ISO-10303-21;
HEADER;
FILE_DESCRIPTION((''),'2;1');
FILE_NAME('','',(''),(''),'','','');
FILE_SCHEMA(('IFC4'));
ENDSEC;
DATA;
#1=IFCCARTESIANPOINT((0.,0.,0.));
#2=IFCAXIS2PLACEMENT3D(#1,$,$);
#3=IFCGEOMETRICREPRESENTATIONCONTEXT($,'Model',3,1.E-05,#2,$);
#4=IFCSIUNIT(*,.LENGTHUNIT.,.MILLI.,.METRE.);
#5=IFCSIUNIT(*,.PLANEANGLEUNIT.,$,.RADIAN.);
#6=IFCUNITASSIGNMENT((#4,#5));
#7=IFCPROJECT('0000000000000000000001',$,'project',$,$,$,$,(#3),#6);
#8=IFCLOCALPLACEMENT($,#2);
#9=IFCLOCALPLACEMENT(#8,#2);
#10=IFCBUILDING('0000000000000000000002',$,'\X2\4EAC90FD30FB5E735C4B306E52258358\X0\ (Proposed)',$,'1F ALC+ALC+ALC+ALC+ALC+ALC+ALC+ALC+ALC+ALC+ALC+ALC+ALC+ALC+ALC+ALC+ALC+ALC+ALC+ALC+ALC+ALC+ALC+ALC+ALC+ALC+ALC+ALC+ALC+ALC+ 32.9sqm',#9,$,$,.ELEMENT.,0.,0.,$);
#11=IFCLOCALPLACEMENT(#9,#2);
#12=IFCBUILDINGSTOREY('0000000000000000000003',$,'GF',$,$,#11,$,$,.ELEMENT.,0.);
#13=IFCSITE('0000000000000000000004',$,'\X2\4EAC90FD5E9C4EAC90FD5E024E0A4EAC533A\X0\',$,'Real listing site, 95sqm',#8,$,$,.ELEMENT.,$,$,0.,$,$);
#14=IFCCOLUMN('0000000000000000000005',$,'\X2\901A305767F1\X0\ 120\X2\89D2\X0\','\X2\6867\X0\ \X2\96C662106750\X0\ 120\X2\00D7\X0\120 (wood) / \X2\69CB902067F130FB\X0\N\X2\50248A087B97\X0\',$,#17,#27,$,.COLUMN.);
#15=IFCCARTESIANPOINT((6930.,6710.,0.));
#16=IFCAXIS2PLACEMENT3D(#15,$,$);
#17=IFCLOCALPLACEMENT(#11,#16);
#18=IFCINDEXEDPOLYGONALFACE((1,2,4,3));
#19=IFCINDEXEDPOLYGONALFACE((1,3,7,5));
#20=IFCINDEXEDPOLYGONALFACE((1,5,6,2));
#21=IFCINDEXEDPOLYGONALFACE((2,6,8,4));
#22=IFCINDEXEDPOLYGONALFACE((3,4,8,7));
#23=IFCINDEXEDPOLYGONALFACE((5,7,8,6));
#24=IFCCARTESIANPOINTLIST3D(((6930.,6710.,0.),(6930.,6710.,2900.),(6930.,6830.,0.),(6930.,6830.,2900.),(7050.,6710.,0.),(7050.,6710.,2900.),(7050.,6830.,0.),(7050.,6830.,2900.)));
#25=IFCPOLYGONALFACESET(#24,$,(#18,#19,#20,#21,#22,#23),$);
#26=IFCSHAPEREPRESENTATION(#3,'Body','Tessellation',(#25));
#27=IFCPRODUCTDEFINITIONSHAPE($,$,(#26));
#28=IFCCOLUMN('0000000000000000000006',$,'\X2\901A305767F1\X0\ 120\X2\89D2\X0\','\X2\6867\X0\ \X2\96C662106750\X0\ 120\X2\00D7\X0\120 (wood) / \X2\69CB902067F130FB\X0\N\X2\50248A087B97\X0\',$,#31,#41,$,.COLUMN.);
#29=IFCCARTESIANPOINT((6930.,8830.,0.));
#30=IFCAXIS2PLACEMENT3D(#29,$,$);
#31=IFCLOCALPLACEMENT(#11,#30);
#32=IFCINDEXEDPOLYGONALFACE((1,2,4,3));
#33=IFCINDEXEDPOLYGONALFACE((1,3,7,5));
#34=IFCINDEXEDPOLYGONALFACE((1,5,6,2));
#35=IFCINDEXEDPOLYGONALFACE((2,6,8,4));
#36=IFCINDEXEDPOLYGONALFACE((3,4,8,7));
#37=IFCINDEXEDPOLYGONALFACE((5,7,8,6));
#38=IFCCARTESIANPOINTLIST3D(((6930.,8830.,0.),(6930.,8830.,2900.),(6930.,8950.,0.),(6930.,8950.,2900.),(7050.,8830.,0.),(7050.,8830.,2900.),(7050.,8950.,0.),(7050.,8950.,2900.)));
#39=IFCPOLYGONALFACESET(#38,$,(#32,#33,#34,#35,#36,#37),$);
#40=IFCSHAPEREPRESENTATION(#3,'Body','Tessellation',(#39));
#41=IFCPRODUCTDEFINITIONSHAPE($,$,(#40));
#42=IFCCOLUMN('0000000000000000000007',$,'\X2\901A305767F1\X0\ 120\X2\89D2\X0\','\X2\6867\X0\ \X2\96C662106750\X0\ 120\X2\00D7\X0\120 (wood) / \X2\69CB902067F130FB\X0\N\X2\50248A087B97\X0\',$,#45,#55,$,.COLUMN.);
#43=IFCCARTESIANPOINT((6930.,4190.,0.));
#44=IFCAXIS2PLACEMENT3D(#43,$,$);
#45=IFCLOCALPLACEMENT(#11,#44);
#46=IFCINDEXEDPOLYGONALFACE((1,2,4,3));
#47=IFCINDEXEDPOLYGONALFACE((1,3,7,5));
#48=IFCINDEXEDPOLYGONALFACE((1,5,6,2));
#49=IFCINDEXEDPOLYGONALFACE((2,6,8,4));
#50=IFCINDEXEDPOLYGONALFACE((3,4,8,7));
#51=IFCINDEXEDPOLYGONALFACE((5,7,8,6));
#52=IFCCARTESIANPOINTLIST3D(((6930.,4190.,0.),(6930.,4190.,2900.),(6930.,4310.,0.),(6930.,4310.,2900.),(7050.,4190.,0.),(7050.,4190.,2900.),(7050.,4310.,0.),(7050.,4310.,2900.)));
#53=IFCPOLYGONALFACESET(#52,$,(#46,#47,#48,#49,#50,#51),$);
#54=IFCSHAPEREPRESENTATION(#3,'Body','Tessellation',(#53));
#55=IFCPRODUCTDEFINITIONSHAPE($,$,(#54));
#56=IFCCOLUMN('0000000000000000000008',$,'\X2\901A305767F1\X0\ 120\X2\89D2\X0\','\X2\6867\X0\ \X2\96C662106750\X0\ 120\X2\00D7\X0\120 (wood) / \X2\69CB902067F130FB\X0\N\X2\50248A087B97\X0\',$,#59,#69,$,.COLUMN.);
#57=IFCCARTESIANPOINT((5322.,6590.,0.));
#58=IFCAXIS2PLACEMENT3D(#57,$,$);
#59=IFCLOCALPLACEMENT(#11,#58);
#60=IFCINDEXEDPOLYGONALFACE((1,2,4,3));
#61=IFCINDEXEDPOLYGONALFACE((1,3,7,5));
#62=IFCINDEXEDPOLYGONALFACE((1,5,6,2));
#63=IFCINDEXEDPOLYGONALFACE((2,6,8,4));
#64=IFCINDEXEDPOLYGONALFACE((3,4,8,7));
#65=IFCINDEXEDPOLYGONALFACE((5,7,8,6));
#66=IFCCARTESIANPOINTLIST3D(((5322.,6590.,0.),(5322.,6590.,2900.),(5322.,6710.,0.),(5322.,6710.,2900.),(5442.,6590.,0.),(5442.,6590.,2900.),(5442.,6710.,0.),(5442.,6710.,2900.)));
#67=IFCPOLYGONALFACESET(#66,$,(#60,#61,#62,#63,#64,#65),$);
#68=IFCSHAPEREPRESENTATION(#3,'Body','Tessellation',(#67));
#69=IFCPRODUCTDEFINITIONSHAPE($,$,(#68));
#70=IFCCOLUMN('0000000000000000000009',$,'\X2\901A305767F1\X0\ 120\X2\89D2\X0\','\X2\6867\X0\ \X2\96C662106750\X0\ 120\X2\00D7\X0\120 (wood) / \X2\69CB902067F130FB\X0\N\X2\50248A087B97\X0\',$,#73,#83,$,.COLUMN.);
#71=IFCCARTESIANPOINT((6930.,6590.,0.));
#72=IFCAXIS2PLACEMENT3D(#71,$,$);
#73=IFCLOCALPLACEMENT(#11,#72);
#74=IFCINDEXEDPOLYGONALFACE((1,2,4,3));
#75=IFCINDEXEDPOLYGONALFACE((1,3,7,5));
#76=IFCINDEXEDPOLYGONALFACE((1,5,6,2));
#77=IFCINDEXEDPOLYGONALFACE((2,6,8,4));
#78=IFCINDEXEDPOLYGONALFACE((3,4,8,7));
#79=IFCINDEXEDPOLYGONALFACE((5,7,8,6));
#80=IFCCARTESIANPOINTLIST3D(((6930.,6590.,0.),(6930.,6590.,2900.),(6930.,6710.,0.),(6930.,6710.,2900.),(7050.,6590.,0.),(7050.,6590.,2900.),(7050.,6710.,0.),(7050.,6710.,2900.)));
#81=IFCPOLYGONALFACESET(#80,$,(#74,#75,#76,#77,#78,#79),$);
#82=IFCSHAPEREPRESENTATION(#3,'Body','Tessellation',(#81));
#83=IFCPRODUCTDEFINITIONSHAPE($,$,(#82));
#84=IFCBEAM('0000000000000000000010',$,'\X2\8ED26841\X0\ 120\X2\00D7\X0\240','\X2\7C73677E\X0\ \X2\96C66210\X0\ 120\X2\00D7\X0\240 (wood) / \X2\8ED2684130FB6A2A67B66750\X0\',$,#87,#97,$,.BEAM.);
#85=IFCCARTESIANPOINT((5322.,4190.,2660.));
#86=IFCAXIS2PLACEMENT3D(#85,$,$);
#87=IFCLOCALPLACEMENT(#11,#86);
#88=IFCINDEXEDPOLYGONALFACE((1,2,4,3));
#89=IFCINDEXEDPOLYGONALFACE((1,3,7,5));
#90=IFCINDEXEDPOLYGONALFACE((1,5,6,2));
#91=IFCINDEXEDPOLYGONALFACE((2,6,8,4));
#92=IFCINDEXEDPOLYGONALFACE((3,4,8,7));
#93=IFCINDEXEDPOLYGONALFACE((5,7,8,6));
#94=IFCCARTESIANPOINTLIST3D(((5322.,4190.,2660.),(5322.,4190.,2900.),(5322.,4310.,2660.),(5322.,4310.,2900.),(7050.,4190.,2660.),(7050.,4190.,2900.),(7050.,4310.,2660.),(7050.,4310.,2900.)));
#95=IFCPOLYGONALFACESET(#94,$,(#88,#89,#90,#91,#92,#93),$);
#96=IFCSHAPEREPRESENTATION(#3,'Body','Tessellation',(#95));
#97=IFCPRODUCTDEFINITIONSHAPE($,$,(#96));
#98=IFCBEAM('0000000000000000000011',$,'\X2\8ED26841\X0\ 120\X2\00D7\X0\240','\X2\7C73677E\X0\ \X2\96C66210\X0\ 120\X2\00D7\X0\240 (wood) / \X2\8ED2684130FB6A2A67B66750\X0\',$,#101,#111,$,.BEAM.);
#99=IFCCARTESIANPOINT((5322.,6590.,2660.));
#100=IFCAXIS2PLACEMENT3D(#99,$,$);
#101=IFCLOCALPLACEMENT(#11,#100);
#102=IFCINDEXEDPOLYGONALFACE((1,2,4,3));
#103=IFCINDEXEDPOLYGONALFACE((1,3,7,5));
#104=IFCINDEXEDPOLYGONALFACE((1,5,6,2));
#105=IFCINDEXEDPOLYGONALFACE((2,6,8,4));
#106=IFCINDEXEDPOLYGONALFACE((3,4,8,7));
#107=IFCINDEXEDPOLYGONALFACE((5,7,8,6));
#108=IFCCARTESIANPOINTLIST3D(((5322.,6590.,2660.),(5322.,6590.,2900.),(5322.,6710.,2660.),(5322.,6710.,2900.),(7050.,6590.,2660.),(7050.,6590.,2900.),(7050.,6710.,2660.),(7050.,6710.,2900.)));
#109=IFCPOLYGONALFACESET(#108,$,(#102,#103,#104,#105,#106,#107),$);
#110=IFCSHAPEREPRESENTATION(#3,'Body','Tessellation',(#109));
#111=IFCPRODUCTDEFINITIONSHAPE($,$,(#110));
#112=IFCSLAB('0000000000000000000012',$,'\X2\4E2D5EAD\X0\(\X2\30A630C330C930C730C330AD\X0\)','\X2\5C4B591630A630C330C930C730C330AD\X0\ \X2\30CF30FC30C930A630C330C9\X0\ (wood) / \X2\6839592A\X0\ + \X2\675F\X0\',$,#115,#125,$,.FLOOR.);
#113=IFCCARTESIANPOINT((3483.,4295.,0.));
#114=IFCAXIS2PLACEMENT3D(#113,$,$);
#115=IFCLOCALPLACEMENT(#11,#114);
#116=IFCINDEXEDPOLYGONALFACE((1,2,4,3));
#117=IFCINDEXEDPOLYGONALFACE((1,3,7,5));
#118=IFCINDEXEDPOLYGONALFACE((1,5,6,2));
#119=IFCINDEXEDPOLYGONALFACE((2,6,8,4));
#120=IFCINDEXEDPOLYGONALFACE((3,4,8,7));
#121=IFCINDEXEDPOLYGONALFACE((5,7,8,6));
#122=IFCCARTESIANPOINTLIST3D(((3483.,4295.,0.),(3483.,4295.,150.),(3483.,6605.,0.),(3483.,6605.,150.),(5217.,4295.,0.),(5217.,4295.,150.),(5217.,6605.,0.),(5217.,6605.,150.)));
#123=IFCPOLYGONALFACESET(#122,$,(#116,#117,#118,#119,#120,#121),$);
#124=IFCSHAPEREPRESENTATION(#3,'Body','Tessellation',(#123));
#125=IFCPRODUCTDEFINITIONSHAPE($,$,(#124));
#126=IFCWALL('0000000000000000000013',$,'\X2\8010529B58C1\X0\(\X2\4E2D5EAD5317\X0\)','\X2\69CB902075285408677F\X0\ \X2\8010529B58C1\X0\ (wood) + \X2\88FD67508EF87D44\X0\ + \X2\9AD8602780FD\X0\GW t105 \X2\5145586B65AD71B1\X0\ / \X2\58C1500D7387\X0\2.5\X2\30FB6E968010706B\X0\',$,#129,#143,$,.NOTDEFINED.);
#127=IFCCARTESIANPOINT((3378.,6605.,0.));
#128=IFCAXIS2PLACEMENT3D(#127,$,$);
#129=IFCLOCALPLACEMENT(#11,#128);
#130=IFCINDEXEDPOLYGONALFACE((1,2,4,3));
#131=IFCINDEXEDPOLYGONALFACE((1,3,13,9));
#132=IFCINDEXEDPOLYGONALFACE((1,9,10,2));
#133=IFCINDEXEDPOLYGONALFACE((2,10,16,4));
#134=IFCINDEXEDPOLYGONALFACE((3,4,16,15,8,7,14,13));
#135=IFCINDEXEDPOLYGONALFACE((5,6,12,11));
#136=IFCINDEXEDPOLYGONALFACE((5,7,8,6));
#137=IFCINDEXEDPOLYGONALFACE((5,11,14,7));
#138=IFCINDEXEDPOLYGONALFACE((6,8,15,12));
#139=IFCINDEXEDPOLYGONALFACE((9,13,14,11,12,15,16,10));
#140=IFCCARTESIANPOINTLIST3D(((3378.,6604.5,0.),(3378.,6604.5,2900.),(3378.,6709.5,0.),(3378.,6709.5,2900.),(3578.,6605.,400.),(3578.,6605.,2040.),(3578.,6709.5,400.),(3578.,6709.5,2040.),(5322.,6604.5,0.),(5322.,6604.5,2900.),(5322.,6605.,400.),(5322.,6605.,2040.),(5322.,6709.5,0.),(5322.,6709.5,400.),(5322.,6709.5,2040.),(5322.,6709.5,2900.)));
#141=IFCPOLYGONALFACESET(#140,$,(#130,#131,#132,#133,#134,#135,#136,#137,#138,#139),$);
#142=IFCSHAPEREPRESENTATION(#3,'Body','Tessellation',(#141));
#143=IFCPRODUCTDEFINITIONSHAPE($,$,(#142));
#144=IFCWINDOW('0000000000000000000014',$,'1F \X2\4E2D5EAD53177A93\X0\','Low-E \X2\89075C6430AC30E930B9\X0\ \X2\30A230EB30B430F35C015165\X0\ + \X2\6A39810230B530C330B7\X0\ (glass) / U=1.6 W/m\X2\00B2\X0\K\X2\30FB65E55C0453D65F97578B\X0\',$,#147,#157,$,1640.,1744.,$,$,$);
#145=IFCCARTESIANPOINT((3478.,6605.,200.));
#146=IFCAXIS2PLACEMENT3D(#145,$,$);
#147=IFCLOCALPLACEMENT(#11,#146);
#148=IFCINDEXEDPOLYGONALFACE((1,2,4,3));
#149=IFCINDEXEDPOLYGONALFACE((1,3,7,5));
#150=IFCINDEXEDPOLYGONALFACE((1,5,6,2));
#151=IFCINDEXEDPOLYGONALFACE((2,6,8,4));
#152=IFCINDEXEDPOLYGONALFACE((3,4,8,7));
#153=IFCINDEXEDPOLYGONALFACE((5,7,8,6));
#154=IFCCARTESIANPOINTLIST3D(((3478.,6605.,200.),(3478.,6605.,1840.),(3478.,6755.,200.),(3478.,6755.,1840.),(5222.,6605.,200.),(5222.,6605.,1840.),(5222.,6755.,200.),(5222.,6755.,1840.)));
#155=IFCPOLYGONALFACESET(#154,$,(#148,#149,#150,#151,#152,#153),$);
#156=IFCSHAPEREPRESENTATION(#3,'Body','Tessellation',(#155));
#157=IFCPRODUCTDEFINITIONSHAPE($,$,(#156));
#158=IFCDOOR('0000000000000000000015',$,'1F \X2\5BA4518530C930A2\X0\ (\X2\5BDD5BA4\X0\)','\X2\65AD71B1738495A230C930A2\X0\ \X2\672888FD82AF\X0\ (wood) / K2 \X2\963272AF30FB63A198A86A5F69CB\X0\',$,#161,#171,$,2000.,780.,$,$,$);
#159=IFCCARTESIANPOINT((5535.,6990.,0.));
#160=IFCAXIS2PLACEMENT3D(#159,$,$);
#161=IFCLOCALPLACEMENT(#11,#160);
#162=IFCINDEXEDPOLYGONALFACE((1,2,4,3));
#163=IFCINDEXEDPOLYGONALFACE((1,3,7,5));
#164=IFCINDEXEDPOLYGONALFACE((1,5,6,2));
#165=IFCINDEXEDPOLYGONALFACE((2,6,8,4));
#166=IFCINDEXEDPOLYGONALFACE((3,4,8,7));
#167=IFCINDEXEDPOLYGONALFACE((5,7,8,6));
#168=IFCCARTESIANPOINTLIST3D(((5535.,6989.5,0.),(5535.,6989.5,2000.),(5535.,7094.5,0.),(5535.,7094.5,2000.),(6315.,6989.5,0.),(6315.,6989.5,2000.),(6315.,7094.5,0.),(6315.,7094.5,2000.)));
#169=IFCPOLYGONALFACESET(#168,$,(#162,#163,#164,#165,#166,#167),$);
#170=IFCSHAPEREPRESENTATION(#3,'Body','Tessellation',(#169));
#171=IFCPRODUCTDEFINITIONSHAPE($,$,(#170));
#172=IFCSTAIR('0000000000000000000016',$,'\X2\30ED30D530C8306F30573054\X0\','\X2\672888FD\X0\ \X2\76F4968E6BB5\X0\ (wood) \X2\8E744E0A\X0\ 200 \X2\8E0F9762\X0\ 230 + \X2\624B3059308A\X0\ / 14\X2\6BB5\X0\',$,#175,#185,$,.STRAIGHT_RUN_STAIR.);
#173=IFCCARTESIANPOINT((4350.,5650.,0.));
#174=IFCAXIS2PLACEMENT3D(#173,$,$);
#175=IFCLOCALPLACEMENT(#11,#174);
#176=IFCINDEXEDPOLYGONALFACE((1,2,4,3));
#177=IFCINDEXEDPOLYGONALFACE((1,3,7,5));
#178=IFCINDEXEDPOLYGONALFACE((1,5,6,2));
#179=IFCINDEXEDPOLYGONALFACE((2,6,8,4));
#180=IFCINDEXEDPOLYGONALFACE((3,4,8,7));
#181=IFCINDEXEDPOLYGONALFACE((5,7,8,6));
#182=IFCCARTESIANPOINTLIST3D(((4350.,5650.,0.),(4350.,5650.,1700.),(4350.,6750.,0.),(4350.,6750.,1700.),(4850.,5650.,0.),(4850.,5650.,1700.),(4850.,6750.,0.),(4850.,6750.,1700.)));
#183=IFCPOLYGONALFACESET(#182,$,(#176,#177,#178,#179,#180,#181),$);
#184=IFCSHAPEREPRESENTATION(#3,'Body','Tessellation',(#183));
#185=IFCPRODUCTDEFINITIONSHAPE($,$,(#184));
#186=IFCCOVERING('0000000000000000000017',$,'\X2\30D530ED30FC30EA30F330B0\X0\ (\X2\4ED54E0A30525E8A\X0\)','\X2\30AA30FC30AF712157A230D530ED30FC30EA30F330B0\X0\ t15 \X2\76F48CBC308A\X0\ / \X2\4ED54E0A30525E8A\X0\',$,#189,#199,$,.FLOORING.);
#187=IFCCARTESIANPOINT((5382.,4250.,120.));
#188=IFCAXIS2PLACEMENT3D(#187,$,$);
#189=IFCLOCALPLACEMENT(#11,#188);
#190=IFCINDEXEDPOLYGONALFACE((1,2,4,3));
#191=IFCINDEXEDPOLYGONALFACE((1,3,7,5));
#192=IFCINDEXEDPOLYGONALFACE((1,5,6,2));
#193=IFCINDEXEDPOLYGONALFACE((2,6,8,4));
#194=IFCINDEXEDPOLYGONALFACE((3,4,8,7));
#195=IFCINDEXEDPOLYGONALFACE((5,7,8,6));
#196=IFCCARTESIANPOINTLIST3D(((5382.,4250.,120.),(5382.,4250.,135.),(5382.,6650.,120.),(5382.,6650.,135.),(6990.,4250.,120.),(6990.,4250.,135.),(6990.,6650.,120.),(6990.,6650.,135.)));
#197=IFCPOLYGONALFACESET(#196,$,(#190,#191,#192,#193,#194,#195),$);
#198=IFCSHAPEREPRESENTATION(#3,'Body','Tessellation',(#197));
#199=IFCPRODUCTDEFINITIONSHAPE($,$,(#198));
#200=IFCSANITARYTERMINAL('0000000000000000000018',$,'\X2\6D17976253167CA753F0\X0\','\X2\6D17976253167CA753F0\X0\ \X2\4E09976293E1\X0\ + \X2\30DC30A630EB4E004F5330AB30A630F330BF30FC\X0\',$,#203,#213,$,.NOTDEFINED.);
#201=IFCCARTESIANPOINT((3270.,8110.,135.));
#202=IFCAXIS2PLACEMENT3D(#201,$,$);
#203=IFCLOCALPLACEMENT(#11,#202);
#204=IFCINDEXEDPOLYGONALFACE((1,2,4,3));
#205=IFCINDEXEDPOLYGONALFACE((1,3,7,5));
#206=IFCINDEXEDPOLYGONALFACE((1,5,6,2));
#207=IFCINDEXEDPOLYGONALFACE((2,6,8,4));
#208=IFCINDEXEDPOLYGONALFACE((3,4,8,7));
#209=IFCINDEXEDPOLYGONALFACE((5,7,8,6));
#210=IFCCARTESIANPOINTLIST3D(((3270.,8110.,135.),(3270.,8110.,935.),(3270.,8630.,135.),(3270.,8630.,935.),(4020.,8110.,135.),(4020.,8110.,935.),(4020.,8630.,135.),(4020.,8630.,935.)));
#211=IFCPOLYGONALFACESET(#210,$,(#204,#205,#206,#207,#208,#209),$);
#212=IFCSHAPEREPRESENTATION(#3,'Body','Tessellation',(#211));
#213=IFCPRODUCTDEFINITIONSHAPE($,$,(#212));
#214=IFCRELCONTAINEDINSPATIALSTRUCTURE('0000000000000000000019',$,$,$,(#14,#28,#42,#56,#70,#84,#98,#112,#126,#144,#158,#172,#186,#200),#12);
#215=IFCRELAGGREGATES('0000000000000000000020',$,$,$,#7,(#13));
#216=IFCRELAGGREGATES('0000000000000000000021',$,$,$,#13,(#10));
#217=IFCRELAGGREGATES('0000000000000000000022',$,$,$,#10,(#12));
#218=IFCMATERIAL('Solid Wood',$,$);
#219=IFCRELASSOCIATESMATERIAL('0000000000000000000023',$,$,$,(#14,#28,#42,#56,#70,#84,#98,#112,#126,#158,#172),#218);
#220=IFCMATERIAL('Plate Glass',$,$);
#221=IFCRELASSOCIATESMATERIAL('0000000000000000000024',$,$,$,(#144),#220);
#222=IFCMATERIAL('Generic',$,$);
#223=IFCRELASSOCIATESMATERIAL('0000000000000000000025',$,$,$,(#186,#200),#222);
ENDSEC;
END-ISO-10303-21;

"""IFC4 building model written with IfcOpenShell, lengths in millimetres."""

from ifc_helpers import new_model, si_unit, frame, frame_2d, origin, place, context, project, spatial, rectangle, extrude, material, element, fill, save


model = new_model("IFC4")

# Units and contexts
model_context = context("Model", 3, precision=1e-05, world=origin())
ifc_project = project(units=[si_unit("LENGTHUNIT", "METRE", prefix="MILLI"), si_unit("PLANEANGLEUNIT", "RADIAN")], contexts=[model_context])

# Site, building, storey
site_placement = place(None, origin())
site = spatial("IfcSite", under=ifc_project, at=site_placement, Name="京都府京都市上京区", ObjectType="Real listing site, 95sqm", CompositionType="ELEMENT", RefElevation=0.0)
building_placement = place(site_placement, origin())
building = spatial("IfcBuilding", under=site, at=building_placement, Name="京都・平屋の別荘 (Proposed)", ObjectType="1F ALC+ALC+ALC+ALC+ALC+ALC+ALC+ALC+ALC+ALC+ALC+ALC+ALC+ALC+ALC+ALC+ALC+ALC+ALC+ALC+ALC+ALC+ALC+ALC+ALC+ALC+ALC+ALC+ALC+ALC+ 32.9sqm", CompositionType="ELEMENT", ElevationOfRefHeight=0.0, ElevationOfTerrain=0.0)
storey_placement = place(building_placement, origin())
storey = spatial("IfcBuildingStorey", under=building, at=storey_placement, Name="GF", CompositionType="ELEMENT", Elevation=0.0)

# Columns
ifc_material_1 = material(Name="Solid Wood")
column_1_placement = place(storey_placement, frame((6930.0, 6710.0, 0.0)))
element("IfcColumn", 1, at=column_1_placement, inside=storey, material=ifc_material_1, Name="通し柱 120角", Description="桧 集成材 120×120 (wood) / 構造柱・N値計算", PredefinedType="COLUMN", context=model_context, shape_type="SweptSolid", body=[
    extrude(rectangle(XDim=120.0, YDim=120.0, at=frame_2d((60.0, 60.0))), frame((6930.0, 6710.0, 0.0)), (0.0, 0.0, 1.0), 2900.0),
])
column_2_placement = place(storey_placement, frame((6930.0, 8830.0, 0.0)))
element("IfcColumn", 2, at=column_2_placement, inside=storey, material=ifc_material_1, Name="通し柱 120角", Description="桧 集成材 120×120 (wood) / 構造柱・N値計算", PredefinedType="COLUMN", context=model_context, shape_type="SweptSolid", body=[
    extrude(rectangle(XDim=120.0, YDim=120.0, at=frame_2d((60.0, 60.0))), frame((6930.0, 8830.0, 0.0)), (0.0, 0.0, 1.0), 2900.0),
])
column_3_placement = place(storey_placement, frame((6930.0, 4190.0, 0.0)))
element("IfcColumn", 3, at=column_3_placement, inside=storey, material=ifc_material_1, Name="通し柱 120角", Description="桧 集成材 120×120 (wood) / 構造柱・N値計算", PredefinedType="COLUMN", context=model_context, shape_type="SweptSolid", body=[
    extrude(rectangle(XDim=120.0, YDim=120.0, at=frame_2d((60.0, 60.0))), frame((6930.0, 4190.0, 0.0)), (0.0, 0.0, 1.0), 2900.0),
])
column_4_placement = place(storey_placement, frame((5322.0, 6590.0, 0.0)))
element("IfcColumn", 4, at=column_4_placement, inside=storey, material=ifc_material_1, Name="通し柱 120角", Description="桧 集成材 120×120 (wood) / 構造柱・N値計算", PredefinedType="COLUMN", context=model_context, shape_type="SweptSolid", body=[
    extrude(rectangle(XDim=120.0, YDim=120.0, at=frame_2d((60.0, 60.0))), frame((5322.0, 6590.0, 0.0)), (0.0, 0.0, 1.0), 2900.0),
])
column_5_placement = place(storey_placement, frame((6930.0, 6590.0, 0.0)))
element("IfcColumn", 5, at=column_5_placement, inside=storey, material=ifc_material_1, Name="通し柱 120角", Description="桧 集成材 120×120 (wood) / 構造柱・N値計算", PredefinedType="COLUMN", context=model_context, shape_type="SweptSolid", body=[
    extrude(rectangle(XDim=120.0, YDim=120.0, at=frame_2d((60.0, 60.0))), frame((6930.0, 6590.0, 0.0)), (0.0, 0.0, 1.0), 2900.0),
])

# Beams
beam_1_placement = place(storey_placement, frame((5322.0, 4190.0, 2660.0)))
element("IfcBeam", 6, at=beam_1_placement, inside=storey, material=ifc_material_1, Name="軒桁 120×240", Description="米松 集成 120×240 (wood) / 軒桁・横架材", PredefinedType="BEAM", context=model_context, shape_type="SweptSolid", body=[
    extrude(rectangle(XDim=1728.0, YDim=120.0, at=frame_2d((864.0, 60.0))), frame((5322.0, 4190.0, 2660.0)), (0.0, 0.0, 1.0), 240.0),
])
beam_2_placement = place(storey_placement, frame((5322.0, 6590.0, 2660.0)))
element("IfcBeam", 7, at=beam_2_placement, inside=storey, material=ifc_material_1, Name="軒桁 120×240", Description="米松 集成 120×240 (wood) / 軒桁・横架材", PredefinedType="BEAM", context=model_context, shape_type="SweptSolid", body=[
    extrude(rectangle(XDim=1728.0, YDim=120.0, at=frame_2d((864.0, 60.0))), frame((5322.0, 6590.0, 2660.0)), (0.0, 0.0, 1.0), 240.0),
])

# Slab
slab_placement = place(storey_placement, frame((3483.0, 4295.0, 0.0)))
element("IfcSlab", 8, at=slab_placement, inside=storey, material=ifc_material_1, Name="中庭(ウッドデッキ)", Description="屋外ウッドデッキ ハードウッド (wood) / 根太 + 束", PredefinedType="FLOOR", context=model_context, shape_type="SweptSolid", body=[
    extrude(rectangle(XDim=1734.0, YDim=2310.0, at=frame_2d((867.0, 1155.0))), frame((3483.0, 4295.0, 0.0)), (0.0, 0.0, 1.0), 150.0),
])

# Wall, opening, window
wall_1_placement = place(storey_placement, frame((3378.0, 6605.0, 0.0)))
wall_1 = element("IfcWall", 9, at=wall_1_placement, inside=storey, material=ifc_material_1, Name="耐力壁(中庭北)", Description="構造用合板 耐力壁 (wood) + 製材軸組 + 高性能GW t105 充填断熱 / 壁倍率2.5・準耐火", PredefinedType="NOTDEFINED", context=model_context, shape_type="SweptSolid", body=[
    extrude(rectangle(XDim=1944.0, YDim=105.0, at=frame_2d((972.0, 52.0))), frame((3378.0, 6605.0, 0.0)), (0.0, 0.0, 1.0), 2900.0),
])
opening_placement = place(storey_placement, frame((3478.0, 6605.0, 200.0)))
opening = element("IfcOpeningElement", 10, at=opening_placement, cuts=wall_1, PredefinedType="NOTDEFINED", context=model_context, shape_type="SweptSolid", body=[
    extrude(rectangle(XDim=1744.0, YDim=150.0, at=frame_2d((872.0, 75.0))), frame((3478.0, 6605.0, 200.0)), (0.0, 0.0, 1.0), 1640.0),
])
ifc_material_2 = material(Name="Plate Glass")
window_placement = place(storey_placement, frame((3478.0, 6605.0, 200.0)))
window = element("IfcWindow", 11, at=window_placement, inside=storey, material=ifc_material_2, Name="1F 中庭北窓", Description="Low-E 複層ガラス アルゴン封入 + 樹脂サッシ (glass) / U=1.6 W/m²K・日射取得型", OverallHeight=1640.0, OverallWidth=1744.0, context=model_context, shape_type="SweptSolid", body=[
    extrude(rectangle(XDim=1744.0, YDim=150.0, at=frame_2d((872.0, 75.0))), frame((3478.0, 6605.0, 200.0)), (0.0, 0.0, 1.0), 1640.0),
])
fill(opening, window)

# Door
door_placement = place(storey_placement, frame((5535.0, 6990.0, 0.0)))
element("IfcDoor", 12, at=door_placement, inside=storey, material=ifc_material_1, Name="1F 室内ドア (寝室)", Description="断熱玄関ドア 木製芯 (wood) / K2 防犯・採風機構", OverallHeight=2000.0, OverallWidth=780.0, context=model_context, shape_type="SweptSolid", body=[
    extrude(rectangle(XDim=780.0, YDim=105.0, at=frame_2d((390.0, 52.0))), frame((5535.0, 6990.0, 0.0)), (0.0, 0.0, 1.0), 2000.0),
])

# Stair
stair_placement = place(storey_placement, frame((4350.0, 5650.0, 0.0)))
element("IfcStair", 13, at=stair_placement, inside=storey, material=ifc_material_1, Name="ロフトはしご", Description="木製 直階段 (wood) 蹴上 200 踏面 230 + 手すり / 14段", PredefinedType="STRAIGHT_RUN_STAIR", context=model_context, shape_type="SweptSolid", body=[
    extrude(rectangle(XDim=500.0, YDim=1100.0, at=frame_2d((250.0, 550.0))), frame((4350.0, 5650.0, 0.0)), (0.0, 0.0, 1.0), 1700.0),
])

# Covering
ifc_material_3 = material(Name="Generic")
covering_placement = place(storey_placement, frame((5382.0, 4250.0, 120.0)))
element("IfcCovering", 14, at=covering_placement, inside=storey, material=ifc_material_3, Name="フローリング (仕上げ床)", Description="オーク無垢フローリング t15 直貼り / 仕上げ床", PredefinedType="FLOORING", context=model_context, shape_type="SweptSolid", body=[
    extrude(rectangle(XDim=1608.0, YDim=2400.0, at=frame_2d((804.0, 1200.0))), frame((5382.0, 4250.0, 120.0)), (0.0, 0.0, 1.0), 15.0),
])

# Sanitary terminal
sanitary_terminal_1_placement = place(storey_placement, frame((3270.0, 8110.0, 135.0)))
element("IfcSanitaryTerminal", 15, at=sanitary_terminal_1_placement, inside=storey, material=ifc_material_3, Name="洗面化粧台", Description="洗面化粧台 三面鏡 + ボウル一体カウンター", PredefinedType="NOTDEFINED", context=model_context, shape_type="SweptSolid", body=[
    extrude(rectangle(XDim=750.0, YDim=520.0, at=frame_2d((375.0, 260.0))), frame((3270.0, 8110.0, 135.0)), (0.0, 0.0, 1.0), 800.0),
])

save(model, "model.ifc")
